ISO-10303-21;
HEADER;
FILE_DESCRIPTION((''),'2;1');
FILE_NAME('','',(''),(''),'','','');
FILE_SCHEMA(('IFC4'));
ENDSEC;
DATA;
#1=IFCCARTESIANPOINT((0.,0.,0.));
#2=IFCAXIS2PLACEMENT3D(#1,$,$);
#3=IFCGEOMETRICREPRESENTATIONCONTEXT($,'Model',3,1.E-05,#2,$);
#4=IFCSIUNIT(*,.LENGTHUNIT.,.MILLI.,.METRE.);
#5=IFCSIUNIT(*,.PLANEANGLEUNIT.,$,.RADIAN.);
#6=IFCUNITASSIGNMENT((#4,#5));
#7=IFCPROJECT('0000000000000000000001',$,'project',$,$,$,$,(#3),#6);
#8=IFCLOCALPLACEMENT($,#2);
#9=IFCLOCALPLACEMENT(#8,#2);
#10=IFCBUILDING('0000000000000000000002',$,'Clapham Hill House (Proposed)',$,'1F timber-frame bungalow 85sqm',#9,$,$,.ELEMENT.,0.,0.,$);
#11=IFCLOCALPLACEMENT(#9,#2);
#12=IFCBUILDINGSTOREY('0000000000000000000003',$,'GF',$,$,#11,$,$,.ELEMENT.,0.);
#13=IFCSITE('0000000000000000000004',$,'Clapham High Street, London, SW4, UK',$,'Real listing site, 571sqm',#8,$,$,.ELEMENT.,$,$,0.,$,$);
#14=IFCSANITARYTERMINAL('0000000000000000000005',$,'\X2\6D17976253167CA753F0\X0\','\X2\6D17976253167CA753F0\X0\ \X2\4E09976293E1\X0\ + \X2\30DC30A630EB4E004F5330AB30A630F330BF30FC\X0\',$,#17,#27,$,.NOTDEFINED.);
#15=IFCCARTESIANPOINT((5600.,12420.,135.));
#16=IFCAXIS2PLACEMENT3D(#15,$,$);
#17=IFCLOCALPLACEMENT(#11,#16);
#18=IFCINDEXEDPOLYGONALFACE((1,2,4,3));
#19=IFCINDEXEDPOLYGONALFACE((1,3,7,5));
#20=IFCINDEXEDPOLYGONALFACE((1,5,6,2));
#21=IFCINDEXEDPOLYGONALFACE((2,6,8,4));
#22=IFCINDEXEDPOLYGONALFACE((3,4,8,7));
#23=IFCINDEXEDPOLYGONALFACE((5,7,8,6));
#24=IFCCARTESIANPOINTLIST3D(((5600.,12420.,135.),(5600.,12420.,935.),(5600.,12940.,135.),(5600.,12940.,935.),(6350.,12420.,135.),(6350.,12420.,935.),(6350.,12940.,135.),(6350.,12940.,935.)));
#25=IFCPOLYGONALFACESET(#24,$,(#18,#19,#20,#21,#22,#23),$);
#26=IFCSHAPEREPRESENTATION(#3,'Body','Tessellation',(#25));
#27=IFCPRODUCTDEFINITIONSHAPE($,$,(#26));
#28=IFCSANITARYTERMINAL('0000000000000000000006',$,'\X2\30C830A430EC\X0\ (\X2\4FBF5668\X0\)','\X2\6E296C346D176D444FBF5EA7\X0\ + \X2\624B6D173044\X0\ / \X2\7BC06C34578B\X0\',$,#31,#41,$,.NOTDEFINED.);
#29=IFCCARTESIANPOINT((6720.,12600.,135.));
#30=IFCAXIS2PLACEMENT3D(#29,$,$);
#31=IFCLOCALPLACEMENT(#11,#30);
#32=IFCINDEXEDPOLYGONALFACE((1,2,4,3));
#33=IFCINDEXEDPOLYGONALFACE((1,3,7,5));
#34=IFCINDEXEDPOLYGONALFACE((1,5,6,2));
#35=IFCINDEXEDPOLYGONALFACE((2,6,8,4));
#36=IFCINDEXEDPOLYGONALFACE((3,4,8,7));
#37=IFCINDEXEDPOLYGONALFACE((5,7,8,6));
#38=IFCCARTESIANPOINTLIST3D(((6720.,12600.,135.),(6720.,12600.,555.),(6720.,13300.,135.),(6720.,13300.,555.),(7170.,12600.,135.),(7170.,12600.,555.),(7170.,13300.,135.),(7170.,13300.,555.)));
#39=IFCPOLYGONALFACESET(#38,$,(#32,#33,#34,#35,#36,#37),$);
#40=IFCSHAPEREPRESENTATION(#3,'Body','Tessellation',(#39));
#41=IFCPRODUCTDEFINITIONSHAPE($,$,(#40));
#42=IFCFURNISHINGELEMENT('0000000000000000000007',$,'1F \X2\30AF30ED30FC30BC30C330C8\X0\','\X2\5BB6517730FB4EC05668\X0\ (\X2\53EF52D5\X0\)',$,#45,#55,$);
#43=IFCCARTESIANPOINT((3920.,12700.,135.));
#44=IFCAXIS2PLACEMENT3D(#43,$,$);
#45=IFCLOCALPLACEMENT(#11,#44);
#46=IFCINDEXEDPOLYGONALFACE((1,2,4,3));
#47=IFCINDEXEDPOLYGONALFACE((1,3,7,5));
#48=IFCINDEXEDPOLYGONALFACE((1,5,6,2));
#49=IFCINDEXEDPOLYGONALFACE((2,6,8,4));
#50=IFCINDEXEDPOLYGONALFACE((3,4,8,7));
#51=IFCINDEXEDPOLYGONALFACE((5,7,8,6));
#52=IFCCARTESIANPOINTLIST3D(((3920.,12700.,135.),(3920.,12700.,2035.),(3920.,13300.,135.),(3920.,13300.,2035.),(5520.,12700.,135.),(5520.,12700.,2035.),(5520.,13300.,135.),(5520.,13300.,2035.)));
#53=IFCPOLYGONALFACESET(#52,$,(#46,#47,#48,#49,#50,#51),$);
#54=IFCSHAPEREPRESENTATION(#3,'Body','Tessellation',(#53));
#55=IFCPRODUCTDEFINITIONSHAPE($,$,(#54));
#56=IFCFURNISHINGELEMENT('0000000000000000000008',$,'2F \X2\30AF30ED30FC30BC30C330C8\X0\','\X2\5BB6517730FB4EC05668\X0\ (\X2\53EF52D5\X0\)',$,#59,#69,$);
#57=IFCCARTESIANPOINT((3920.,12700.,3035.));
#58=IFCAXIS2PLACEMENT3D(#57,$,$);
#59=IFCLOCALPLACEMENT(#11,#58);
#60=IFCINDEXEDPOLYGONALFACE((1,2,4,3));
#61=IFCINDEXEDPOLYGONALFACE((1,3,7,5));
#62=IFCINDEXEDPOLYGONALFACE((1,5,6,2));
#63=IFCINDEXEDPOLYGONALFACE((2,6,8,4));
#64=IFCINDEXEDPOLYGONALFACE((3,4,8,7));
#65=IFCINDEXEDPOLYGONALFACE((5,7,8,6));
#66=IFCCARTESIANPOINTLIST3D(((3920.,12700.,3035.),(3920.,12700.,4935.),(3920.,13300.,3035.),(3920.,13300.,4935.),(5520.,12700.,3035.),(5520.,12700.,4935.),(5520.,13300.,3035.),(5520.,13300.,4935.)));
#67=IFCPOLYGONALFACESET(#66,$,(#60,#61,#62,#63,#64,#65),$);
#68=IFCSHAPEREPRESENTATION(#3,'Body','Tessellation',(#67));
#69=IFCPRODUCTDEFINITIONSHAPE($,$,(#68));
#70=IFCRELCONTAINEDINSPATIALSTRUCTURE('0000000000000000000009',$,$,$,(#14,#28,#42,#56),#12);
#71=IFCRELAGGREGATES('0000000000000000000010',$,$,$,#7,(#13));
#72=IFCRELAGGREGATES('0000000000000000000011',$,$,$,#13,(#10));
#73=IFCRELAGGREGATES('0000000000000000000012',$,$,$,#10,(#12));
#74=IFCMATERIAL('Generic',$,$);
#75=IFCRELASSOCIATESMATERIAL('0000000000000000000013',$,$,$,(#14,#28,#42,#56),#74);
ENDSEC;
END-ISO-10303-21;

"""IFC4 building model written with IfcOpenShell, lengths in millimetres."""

from ifc_helpers import new_model, si_unit, frame, frame_2d, origin, place, context, project, spatial, rectangle, extrude, material, element, save


model = new_model("IFC4")

# Units and contexts
model_context = context("Model", 3, precision=1e-05, world=origin())
ifc_project = project(units=[si_unit("LENGTHUNIT", "METRE", prefix="MILLI"), si_unit("PLANEANGLEUNIT", "RADIAN")], contexts=[model_context])

# Site, building, storey
site_placement = place(None, origin())
site = spatial("IfcSite", under=ifc_project, at=site_placement, Name="Clapham High Street, London, SW4, UK", ObjectType="Real listing site, 571sqm", CompositionType="ELEMENT", RefElevation=0.0)
building_placement = place(site_placement, origin())
building = spatial("IfcBuilding", under=site, at=building_placement, Name="Clapham Hill House (Proposed)", ObjectType="1F timber-frame bungalow 85sqm", CompositionType="ELEMENT", ElevationOfRefHeight=0.0, ElevationOfTerrain=0.0)
storey_placement = place(building_placement, origin())
storey = spatial("IfcBuildingStorey", under=building, at=storey_placement, Name="GF", CompositionType="ELEMENT", Elevation=0.0)

# Shared definitions
ifc_material_1 = material(Name="Generic")

# Sanitary terminals
sanitary_terminal_1_placement = place(storey_placement, frame((5600.0, 12420.0, 135.0)))
element("IfcSanitaryTerminal", 1, at=sanitary_terminal_1_placement, inside=storey, material=ifc_material_1, Name="洗面化粧台", Description="洗面化粧台 三面鏡 + ボウル一体カウンター", PredefinedType="NOTDEFINED", context=model_context, shape_type="SweptSolid", body=[
    extrude(rectangle(XDim=750.0, YDim=520.0, at=frame_2d((375.0, 260.0))), frame((5600.0, 12420.0, 135.0)), (0.0, 0.0, 1.0), 800.0),
])
sanitary_terminal_2_placement = place(storey_placement, frame((6720.0, 12600.0, 135.0)))
element("IfcSanitaryTerminal", 2, at=sanitary_terminal_2_placement, inside=storey, material=ifc_material_1, Name="トイレ (便器)", Description="温水洗浄便座 + 手洗い / 節水型", PredefinedType="NOTDEFINED", context=model_context, shape_type="SweptSolid", body=[
    extrude(rectangle(XDim=450.0, YDim=700.0, at=frame_2d((225.0, 350.0))), frame((6720.0, 12600.0, 135.0)), (0.0, 0.0, 1.0), 420.0),
])

# Furnishing elements
furnishing_1_placement = place(storey_placement, frame((3920.0, 12700.0, 135.0)))
element("IfcFurnishingElement", 3, at=furnishing_1_placement, inside=storey, material=ifc_material_1, Name="1F クローゼット", Description="家具・什器 (可動)", context=model_context, shape_type="SweptSolid", body=[
    extrude(rectangle(XDim=1600.0, YDim=600.0, at=frame_2d((800.0, 300.0))), frame((3920.0, 12700.0, 135.0)), (0.0, 0.0, 1.0), 1900.0),
])
furnishing_2_placement = place(storey_placement, frame((3920.0, 12700.0, 3035.0)))
element("IfcFurnishingElement", 4, at=furnishing_2_placement, inside=storey, material=ifc_material_1, Name="2F クローゼット", Description="家具・什器 (可動)", context=model_context, shape_type="SweptSolid", body=[
    extrude(rectangle(XDim=1600.0, YDim=600.0, at=frame_2d((800.0, 300.0))), frame((3920.0, 12700.0, 3035.0)), (0.0, 0.0, 1.0), 1900.0),
])

save(model, "model.ifc")
